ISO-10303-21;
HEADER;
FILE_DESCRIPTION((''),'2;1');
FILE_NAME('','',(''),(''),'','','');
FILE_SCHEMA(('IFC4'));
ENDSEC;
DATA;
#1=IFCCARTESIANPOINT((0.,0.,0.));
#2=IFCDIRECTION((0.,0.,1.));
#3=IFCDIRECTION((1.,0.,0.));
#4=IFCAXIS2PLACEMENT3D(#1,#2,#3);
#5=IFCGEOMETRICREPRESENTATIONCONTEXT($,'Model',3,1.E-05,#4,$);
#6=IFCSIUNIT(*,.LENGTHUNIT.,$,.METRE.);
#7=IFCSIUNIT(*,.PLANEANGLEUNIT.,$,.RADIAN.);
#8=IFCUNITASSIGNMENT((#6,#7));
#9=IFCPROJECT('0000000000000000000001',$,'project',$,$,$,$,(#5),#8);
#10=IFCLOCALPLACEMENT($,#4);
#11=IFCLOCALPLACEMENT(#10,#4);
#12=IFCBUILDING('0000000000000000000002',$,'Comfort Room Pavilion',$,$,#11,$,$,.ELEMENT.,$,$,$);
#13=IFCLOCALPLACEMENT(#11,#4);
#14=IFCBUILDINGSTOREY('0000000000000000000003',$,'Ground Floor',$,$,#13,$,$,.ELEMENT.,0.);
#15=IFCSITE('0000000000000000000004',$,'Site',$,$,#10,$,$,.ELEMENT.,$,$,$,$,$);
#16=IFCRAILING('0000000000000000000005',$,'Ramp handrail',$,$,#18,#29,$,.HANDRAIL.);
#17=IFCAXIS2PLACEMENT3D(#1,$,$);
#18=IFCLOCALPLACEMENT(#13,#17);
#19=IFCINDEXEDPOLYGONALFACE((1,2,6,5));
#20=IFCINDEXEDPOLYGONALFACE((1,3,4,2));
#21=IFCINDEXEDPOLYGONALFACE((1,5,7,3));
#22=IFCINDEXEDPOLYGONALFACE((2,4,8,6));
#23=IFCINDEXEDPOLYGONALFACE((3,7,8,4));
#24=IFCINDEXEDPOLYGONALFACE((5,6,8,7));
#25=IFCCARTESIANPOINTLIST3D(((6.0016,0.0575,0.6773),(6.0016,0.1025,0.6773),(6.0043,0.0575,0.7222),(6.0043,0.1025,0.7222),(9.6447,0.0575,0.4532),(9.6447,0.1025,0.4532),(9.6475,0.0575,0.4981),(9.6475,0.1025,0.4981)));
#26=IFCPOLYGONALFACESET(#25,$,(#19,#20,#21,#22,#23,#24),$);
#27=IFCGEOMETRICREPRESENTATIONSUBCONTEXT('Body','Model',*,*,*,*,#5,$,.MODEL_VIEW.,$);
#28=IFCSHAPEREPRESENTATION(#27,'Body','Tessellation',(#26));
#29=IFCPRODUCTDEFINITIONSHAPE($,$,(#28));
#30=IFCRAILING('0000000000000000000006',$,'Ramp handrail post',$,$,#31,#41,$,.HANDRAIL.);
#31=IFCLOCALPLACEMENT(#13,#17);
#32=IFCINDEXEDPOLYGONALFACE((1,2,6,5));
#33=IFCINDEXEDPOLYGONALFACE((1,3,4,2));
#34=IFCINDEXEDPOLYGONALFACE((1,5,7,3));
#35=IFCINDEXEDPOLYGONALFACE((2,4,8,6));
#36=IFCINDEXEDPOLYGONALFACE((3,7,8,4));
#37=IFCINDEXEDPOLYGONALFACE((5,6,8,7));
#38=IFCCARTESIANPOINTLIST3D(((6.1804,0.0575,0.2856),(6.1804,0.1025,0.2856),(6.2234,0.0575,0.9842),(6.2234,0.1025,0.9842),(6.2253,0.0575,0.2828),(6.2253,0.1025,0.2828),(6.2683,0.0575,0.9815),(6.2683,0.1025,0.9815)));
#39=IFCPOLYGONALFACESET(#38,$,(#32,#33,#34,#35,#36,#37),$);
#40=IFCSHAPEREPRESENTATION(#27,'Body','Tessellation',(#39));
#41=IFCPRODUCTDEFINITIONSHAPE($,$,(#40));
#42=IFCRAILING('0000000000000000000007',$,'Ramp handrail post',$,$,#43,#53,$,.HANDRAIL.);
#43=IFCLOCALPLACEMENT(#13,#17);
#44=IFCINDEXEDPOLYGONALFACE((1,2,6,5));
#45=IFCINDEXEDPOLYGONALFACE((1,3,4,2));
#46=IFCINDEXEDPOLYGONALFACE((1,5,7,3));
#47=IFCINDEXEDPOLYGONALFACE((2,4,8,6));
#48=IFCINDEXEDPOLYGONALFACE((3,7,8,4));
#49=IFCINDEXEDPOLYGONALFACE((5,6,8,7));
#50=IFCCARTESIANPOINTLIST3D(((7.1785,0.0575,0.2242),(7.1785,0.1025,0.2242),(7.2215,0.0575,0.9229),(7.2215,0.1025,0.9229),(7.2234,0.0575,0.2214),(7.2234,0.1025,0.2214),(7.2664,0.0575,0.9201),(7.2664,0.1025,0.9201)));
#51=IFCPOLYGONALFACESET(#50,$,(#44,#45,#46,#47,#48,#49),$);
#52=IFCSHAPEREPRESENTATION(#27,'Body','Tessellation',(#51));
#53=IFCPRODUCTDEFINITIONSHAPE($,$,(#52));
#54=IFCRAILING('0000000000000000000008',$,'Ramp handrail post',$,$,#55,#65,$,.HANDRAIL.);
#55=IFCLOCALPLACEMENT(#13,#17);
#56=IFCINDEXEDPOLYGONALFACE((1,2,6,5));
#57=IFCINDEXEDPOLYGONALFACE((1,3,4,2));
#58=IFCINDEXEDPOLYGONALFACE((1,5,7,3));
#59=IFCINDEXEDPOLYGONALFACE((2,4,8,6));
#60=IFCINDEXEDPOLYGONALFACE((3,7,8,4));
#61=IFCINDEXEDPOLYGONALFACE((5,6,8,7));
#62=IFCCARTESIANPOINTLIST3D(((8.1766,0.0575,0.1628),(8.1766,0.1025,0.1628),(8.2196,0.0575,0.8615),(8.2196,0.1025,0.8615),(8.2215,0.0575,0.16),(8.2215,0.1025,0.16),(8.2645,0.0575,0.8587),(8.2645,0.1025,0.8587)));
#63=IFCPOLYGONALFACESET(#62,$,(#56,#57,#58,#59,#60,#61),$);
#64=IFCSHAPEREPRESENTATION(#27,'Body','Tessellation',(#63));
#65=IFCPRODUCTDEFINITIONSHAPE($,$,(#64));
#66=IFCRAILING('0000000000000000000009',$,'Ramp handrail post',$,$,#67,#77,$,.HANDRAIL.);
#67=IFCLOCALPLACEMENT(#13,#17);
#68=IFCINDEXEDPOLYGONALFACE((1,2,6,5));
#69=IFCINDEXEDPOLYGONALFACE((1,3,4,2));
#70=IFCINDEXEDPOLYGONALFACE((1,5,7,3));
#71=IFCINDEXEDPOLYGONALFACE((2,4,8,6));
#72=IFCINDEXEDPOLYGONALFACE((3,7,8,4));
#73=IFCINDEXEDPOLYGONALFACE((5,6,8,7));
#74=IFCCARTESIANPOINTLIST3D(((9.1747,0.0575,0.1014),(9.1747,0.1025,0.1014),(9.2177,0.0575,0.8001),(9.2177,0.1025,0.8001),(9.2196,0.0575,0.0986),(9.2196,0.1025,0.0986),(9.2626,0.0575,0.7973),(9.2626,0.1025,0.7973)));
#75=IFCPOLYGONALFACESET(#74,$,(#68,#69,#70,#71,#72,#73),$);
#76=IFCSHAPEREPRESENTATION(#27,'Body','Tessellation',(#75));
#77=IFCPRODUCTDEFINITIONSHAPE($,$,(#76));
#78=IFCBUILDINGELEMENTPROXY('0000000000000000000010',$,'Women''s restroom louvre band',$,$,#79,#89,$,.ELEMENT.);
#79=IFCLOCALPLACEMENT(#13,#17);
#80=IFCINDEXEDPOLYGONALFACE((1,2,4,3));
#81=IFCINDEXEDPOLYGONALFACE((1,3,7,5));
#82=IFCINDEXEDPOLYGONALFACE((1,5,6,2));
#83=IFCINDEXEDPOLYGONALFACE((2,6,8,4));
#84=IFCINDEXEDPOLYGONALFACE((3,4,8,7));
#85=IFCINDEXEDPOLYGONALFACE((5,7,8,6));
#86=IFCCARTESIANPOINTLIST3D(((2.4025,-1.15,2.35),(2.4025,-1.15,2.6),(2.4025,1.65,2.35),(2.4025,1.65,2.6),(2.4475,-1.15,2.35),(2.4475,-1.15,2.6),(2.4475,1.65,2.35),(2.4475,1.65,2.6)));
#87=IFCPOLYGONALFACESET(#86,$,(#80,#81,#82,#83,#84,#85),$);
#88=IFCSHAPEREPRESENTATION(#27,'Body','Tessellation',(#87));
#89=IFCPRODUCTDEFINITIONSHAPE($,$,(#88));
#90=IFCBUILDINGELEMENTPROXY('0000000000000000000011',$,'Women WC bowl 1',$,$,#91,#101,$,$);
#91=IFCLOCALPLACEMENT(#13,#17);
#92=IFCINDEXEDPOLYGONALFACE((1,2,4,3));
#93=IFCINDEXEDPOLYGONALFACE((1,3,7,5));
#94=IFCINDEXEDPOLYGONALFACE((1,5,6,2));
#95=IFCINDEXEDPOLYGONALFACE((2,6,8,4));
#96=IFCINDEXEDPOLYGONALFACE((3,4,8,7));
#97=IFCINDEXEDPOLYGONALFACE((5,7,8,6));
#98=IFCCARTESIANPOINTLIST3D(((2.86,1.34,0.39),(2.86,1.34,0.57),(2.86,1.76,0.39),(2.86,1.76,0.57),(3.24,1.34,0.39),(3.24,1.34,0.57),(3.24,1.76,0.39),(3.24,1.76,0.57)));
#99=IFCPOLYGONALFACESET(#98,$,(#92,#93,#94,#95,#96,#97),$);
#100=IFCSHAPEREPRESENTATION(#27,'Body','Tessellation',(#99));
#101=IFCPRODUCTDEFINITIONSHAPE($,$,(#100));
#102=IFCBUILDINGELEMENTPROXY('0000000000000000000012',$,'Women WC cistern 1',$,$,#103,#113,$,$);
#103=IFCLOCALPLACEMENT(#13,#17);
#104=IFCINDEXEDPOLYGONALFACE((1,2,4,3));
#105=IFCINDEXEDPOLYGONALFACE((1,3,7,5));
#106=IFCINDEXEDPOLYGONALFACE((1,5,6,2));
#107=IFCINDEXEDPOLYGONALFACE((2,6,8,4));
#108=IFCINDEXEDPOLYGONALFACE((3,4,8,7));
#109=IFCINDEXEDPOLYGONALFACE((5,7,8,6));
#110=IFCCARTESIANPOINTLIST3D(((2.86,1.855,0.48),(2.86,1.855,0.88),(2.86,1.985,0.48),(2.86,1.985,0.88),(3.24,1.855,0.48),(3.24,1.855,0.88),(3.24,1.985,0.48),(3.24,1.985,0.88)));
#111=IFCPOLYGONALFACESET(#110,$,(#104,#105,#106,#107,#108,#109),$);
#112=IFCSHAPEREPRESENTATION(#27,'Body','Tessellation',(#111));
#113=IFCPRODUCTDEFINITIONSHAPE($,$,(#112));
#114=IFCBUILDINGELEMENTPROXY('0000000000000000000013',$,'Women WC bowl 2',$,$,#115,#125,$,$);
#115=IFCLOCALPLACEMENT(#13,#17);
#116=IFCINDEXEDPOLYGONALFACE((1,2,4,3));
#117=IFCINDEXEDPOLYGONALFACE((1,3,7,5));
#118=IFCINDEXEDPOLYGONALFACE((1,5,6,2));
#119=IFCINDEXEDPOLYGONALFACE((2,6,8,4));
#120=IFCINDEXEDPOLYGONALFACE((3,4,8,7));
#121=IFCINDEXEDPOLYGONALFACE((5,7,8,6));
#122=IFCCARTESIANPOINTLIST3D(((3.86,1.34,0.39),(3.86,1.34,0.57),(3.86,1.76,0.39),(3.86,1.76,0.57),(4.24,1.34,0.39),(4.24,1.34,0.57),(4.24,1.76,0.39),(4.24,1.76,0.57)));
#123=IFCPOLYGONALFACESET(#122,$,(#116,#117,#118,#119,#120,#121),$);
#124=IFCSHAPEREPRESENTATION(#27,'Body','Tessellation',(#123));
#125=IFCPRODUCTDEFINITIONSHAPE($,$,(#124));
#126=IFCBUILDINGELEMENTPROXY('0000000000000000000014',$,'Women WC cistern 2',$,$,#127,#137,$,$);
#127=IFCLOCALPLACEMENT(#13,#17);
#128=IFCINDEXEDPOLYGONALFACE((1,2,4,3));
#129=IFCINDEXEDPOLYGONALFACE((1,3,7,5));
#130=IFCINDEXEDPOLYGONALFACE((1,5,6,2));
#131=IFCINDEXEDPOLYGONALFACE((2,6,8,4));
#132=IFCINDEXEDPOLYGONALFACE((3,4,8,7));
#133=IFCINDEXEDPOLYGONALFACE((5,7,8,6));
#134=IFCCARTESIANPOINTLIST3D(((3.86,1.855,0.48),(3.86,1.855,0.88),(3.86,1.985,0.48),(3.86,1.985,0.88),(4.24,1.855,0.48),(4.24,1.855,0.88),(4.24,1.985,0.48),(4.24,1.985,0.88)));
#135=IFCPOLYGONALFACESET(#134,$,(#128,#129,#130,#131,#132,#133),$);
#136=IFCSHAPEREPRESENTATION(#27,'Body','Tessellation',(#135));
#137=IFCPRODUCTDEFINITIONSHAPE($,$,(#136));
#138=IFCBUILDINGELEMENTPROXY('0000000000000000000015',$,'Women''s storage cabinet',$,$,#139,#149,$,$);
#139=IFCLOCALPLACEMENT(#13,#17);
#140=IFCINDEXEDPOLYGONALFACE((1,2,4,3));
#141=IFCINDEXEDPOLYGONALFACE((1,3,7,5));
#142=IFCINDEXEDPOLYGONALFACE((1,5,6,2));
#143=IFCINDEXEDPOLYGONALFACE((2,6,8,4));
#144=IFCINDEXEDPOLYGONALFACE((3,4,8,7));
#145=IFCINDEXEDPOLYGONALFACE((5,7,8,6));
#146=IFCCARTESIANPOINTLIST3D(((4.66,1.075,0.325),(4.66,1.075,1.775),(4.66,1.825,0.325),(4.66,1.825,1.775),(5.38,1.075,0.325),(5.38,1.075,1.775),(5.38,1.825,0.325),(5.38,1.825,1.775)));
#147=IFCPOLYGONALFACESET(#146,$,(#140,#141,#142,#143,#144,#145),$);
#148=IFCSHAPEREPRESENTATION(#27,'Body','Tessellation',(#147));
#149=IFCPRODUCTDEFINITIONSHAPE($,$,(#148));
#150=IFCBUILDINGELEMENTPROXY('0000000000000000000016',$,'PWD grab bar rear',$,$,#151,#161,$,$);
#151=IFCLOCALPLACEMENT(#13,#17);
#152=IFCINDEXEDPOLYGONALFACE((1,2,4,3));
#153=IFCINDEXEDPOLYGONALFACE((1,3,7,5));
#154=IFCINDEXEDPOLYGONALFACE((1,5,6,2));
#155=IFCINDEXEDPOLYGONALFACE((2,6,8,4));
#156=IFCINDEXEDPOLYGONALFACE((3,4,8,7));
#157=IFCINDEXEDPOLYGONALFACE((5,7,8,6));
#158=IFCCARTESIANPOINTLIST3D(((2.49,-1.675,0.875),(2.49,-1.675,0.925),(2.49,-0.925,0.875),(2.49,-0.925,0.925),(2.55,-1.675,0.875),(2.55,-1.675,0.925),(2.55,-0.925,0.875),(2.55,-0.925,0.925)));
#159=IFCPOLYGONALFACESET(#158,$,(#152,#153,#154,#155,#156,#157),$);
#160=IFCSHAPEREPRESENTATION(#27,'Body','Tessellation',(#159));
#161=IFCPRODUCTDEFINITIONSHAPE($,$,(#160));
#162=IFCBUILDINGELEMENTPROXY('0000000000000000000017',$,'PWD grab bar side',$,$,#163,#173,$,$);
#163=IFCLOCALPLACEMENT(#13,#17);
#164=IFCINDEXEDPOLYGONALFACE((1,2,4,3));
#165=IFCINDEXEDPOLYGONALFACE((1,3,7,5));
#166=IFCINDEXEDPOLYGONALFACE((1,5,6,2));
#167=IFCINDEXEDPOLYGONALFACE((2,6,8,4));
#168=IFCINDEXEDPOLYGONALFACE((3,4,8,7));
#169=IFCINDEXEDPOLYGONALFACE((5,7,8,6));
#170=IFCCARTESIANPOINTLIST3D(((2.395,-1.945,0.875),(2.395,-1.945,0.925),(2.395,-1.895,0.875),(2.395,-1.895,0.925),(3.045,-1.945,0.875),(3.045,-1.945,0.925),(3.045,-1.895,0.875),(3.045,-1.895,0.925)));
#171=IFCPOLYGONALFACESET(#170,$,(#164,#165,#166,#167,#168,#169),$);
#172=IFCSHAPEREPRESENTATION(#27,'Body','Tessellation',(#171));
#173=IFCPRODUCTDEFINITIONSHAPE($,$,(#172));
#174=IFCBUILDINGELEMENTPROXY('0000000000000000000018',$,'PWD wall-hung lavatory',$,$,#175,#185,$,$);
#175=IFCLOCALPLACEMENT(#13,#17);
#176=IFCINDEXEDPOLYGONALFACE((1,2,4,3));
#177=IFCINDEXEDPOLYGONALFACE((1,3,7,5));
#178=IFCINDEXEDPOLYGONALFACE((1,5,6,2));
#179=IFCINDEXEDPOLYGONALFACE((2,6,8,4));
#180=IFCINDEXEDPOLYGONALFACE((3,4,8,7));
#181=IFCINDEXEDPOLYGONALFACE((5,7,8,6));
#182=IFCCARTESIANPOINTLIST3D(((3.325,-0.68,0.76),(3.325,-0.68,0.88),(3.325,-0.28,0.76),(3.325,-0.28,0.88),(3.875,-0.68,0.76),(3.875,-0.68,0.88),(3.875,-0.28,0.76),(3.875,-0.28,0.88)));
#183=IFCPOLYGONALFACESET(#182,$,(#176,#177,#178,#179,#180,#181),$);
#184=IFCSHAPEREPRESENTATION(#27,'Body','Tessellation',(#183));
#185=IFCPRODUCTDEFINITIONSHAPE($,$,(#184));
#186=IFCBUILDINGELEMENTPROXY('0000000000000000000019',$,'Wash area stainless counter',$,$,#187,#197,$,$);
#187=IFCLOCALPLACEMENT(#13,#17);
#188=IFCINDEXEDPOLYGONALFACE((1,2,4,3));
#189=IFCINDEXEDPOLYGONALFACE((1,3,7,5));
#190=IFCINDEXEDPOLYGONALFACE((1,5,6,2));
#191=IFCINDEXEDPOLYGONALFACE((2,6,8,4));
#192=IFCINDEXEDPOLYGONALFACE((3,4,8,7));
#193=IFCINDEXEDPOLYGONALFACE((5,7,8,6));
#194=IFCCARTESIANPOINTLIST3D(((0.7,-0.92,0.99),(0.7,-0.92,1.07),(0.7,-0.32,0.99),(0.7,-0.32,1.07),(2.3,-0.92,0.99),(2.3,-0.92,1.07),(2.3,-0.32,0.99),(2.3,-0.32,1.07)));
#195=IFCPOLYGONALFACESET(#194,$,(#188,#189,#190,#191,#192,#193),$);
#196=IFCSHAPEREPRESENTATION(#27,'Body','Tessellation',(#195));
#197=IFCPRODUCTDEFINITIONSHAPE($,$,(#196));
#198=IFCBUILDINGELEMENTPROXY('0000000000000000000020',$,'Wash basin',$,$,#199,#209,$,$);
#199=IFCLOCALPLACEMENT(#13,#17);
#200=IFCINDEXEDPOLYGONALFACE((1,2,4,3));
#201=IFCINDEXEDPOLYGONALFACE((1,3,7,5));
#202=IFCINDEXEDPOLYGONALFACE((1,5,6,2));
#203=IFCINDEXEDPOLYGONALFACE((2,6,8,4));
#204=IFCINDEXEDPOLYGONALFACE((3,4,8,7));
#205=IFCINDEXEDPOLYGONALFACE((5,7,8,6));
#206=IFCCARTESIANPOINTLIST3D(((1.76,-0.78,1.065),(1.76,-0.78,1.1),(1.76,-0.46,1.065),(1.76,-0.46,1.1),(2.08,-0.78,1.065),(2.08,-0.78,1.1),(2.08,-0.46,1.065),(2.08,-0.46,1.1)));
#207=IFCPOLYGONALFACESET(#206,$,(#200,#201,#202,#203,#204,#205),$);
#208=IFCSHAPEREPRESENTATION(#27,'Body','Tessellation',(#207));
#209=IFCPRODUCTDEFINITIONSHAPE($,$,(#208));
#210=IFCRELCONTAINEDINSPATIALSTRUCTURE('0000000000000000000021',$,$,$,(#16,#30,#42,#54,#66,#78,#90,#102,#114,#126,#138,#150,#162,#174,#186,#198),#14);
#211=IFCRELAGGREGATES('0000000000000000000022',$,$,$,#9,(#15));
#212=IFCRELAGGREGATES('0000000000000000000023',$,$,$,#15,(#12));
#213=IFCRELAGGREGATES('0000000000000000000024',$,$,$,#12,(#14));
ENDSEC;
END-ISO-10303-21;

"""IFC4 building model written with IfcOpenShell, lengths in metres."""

from ifc_helpers import new_model, si_unit, frame, origin_with_axes, origin_2d, place, context, subcontext, project, spatial, rectangle, extrude, element, save


model = new_model("IFC4")

# Units and contexts
model_context = context("Model", 3, precision=1e-05, world=origin_with_axes())
body_context = subcontext(model_context, "Body", "Model", "MODEL_VIEW")
ifc_project = project(units=[si_unit("LENGTHUNIT", "METRE"), si_unit("PLANEANGLEUNIT", "RADIAN")], contexts=[model_context])

# Site, building, storey
site_placement = place(None, origin_with_axes())
site = spatial("IfcSite", under=ifc_project, at=site_placement, Name="Site", CompositionType="ELEMENT")
building_placement = place(site_placement, origin_with_axes())
building = spatial("IfcBuilding", under=site, at=building_placement, Name="Comfort Room Pavilion", CompositionType="ELEMENT")
storey_placement = place(building_placement, origin_with_axes())
storey = spatial("IfcBuildingStorey", under=building, at=storey_placement, Name="Ground Floor", CompositionType="ELEMENT", Elevation=0.0)

# Railings
railing_1_placement = place(storey_placement, frame((7.8231, 0.08, 0.5652), z_axis=(0.061397, 0.0, 0.998113), x_axis=(0.998113, 0.0, -0.061397)))
element("IfcRailing", 1, at=railing_1_placement, inside=storey, Name="Ramp handrail", PredefinedType="HANDRAIL", context=body_context, shape_type="SweptSolid", body=[
    extrude(rectangle(XDim=3.65, YDim=0.045, at=origin_2d()), origin_with_axes(), (0.0, 0.0, 1.0), 0.045),
])
for number, where, z_axis, x_axis, name in (
    (2, (6.2028, 0.08, 0.2842), (0.061397, 0.0, 0.998113), (0.998113, 0.0, -0.061397), "Ramp handrail post"),
    (3, (7.2009, 0.08, 0.2228), (0.061397, 0.0, 0.998113), (0.998113, 0.0, -0.061397), "Ramp handrail post"),
    (4, (8.1991, 0.08, 0.1614), (0.061397, 0.0, 0.998113), (0.998113, 0.0, -0.061397), "Ramp handrail post"),
    (5, (9.1972, 0.08, 0.1), (0.061397, 0.0, 0.998113), (0.998113, 0.0, -0.061397), "Ramp handrail post"),
):
    element("IfcRailing", number, at=place(storey_placement, frame(where, z_axis=z_axis, x_axis=x_axis)), inside=storey, Name=name, PredefinedType="HANDRAIL", context=body_context, shape_type="SweptSolid", body=[
        extrude(rectangle(XDim=0.045, YDim=0.045, at=origin_2d()), origin_with_axes(), (0.0, 0.0, 1.0), 0.7),
    ])

# Building element proxies
proxy_1_placement = place(storey_placement, frame((2.425, 0.25, 2.35), z_axis=(0.0, 0.0, 1.0), x_axis=(1.0, 0.0, 0.0)))
element("IfcBuildingElementProxy", 6, at=proxy_1_placement, inside=storey, Name="Women's restroom louvre band", PredefinedType="ELEMENT", context=body_context, shape_type="SweptSolid", body=[
    extrude(rectangle(XDim=0.045, YDim=2.8, at=origin_2d()), origin_with_axes(), (0.0, 0.0, 1.0), 0.25),
])
proxy_2_placement = place(storey_placement, frame((3.05, 1.55, 0.39), z_axis=(0.0, 0.0, 1.0), x_axis=(1.0, 0.0, 0.0)))
element("IfcBuildingElementProxy", 7, at=proxy_2_placement, inside=storey, Name="Women WC bowl 1", context=body_context, shape_type="SweptSolid", body=[
    extrude(rectangle(XDim=0.38, YDim=0.42, at=origin_2d()), origin_with_axes(), (0.0, 0.0, 1.0), 0.18),
])
proxy_3_placement = place(storey_placement, frame((3.05, 1.92, 0.48), z_axis=(0.0, 0.0, 1.0), x_axis=(1.0, 0.0, 0.0)))
element("IfcBuildingElementProxy", 8, at=proxy_3_placement, inside=storey, Name="Women WC cistern 1", context=body_context, shape_type="SweptSolid", body=[
    extrude(rectangle(XDim=0.38, YDim=0.13, at=origin_2d()), origin_with_axes(), (0.0, 0.0, 1.0), 0.4),
])
proxy_4_placement = place(storey_placement, frame((4.05, 1.55, 0.39), z_axis=(0.0, 0.0, 1.0), x_axis=(1.0, 0.0, 0.0)))
element("IfcBuildingElementProxy", 9, at=proxy_4_placement, inside=storey, Name="Women WC bowl 2", context=body_context, shape_type="SweptSolid", body=[
    extrude(rectangle(XDim=0.38, YDim=0.42, at=origin_2d()), origin_with_axes(), (0.0, 0.0, 1.0), 0.18),
])
proxy_5_placement = place(storey_placement, frame((4.05, 1.92, 0.48), z_axis=(0.0, 0.0, 1.0), x_axis=(1.0, 0.0, 0.0)))
element("IfcBuildingElementProxy", 10, at=proxy_5_placement, inside=storey, Name="Women WC cistern 2", context=body_context, shape_type="SweptSolid", body=[
    extrude(rectangle(XDim=0.38, YDim=0.13, at=origin_2d()), origin_with_axes(), (0.0, 0.0, 1.0), 0.4),
])
proxy_6_placement = place(storey_placement, frame((5.02, 1.45, 0.325), z_axis=(0.0, 0.0, 1.0), x_axis=(1.0, 0.0, 0.0)))
element("IfcBuildingElementProxy", 11, at=proxy_6_placement, inside=storey, Name="Women's storage cabinet", context=body_context, shape_type="SweptSolid", body=[
    extrude(rectangle(XDim=0.72, YDim=0.75, at=origin_2d()), origin_with_axes(), (0.0, 0.0, 1.0), 1.45),
])
proxy_7_placement = place(storey_placement, frame((2.52, -1.3, 0.875), z_axis=(0.0, 0.0, 1.0), x_axis=(1.0, 0.0, 0.0)))
element("IfcBuildingElementProxy", 12, at=proxy_7_placement, inside=storey, Name="PWD grab bar rear", context=body_context, shape_type="SweptSolid", body=[
    extrude(rectangle(XDim=0.06, YDim=0.75, at=origin_2d()), origin_with_axes(), (0.0, 0.0, 1.0), 0.05),
])
proxy_8_placement = place(storey_placement, frame((2.72, -1.92, 0.875), z_axis=(0.0, 0.0, 1.0), x_axis=(1.0, 0.0, 0.0)))
element("IfcBuildingElementProxy", 13, at=proxy_8_placement, inside=storey, Name="PWD grab bar side", context=body_context, shape_type="SweptSolid", body=[
    extrude(rectangle(XDim=0.65, YDim=0.05, at=origin_2d()), origin_with_axes(), (0.0, 0.0, 1.0), 0.05),
])
proxy_9_placement = place(storey_placement, frame((3.6, -0.48, 0.76), z_axis=(0.0, 0.0, 1.0), x_axis=(1.0, 0.0, 0.0)))
element("IfcBuildingElementProxy", 14, at=proxy_9_placement, inside=storey, Name="PWD wall-hung lavatory", context=body_context, shape_type="SweptSolid", body=[
    extrude(rectangle(XDim=0.55, YDim=0.4, at=origin_2d()), origin_with_axes(), (0.0, 0.0, 1.0), 0.12),
])
proxy_10_placement = place(storey_placement, frame((1.5, -0.62, 0.99), z_axis=(0.0, 0.0, 1.0), x_axis=(1.0, 0.0, 0.0)))
element("IfcBuildingElementProxy", 15, at=proxy_10_placement, inside=storey, Name="Wash area stainless counter", context=body_context, shape_type="SweptSolid", body=[
    extrude(rectangle(XDim=1.6, YDim=0.6, at=origin_2d()), origin_with_axes(), (0.0, 0.0, 1.0), 0.08),
])
proxy_11_placement = place(storey_placement, frame((1.92, -0.62, 1.065), z_axis=(0.0, 0.0, 1.0), x_axis=(1.0, 0.0, 0.0)))
element("IfcBuildingElementProxy", 16, at=proxy_11_placement, inside=storey, Name="Wash basin", context=body_context, shape_type="SweptSolid", body=[
    extrude(rectangle(XDim=0.32, YDim=0.32, at=origin_2d()), origin_with_axes(), (0.0, 0.0, 1.0), 0.035),
])

save(model, "model.ifc")
